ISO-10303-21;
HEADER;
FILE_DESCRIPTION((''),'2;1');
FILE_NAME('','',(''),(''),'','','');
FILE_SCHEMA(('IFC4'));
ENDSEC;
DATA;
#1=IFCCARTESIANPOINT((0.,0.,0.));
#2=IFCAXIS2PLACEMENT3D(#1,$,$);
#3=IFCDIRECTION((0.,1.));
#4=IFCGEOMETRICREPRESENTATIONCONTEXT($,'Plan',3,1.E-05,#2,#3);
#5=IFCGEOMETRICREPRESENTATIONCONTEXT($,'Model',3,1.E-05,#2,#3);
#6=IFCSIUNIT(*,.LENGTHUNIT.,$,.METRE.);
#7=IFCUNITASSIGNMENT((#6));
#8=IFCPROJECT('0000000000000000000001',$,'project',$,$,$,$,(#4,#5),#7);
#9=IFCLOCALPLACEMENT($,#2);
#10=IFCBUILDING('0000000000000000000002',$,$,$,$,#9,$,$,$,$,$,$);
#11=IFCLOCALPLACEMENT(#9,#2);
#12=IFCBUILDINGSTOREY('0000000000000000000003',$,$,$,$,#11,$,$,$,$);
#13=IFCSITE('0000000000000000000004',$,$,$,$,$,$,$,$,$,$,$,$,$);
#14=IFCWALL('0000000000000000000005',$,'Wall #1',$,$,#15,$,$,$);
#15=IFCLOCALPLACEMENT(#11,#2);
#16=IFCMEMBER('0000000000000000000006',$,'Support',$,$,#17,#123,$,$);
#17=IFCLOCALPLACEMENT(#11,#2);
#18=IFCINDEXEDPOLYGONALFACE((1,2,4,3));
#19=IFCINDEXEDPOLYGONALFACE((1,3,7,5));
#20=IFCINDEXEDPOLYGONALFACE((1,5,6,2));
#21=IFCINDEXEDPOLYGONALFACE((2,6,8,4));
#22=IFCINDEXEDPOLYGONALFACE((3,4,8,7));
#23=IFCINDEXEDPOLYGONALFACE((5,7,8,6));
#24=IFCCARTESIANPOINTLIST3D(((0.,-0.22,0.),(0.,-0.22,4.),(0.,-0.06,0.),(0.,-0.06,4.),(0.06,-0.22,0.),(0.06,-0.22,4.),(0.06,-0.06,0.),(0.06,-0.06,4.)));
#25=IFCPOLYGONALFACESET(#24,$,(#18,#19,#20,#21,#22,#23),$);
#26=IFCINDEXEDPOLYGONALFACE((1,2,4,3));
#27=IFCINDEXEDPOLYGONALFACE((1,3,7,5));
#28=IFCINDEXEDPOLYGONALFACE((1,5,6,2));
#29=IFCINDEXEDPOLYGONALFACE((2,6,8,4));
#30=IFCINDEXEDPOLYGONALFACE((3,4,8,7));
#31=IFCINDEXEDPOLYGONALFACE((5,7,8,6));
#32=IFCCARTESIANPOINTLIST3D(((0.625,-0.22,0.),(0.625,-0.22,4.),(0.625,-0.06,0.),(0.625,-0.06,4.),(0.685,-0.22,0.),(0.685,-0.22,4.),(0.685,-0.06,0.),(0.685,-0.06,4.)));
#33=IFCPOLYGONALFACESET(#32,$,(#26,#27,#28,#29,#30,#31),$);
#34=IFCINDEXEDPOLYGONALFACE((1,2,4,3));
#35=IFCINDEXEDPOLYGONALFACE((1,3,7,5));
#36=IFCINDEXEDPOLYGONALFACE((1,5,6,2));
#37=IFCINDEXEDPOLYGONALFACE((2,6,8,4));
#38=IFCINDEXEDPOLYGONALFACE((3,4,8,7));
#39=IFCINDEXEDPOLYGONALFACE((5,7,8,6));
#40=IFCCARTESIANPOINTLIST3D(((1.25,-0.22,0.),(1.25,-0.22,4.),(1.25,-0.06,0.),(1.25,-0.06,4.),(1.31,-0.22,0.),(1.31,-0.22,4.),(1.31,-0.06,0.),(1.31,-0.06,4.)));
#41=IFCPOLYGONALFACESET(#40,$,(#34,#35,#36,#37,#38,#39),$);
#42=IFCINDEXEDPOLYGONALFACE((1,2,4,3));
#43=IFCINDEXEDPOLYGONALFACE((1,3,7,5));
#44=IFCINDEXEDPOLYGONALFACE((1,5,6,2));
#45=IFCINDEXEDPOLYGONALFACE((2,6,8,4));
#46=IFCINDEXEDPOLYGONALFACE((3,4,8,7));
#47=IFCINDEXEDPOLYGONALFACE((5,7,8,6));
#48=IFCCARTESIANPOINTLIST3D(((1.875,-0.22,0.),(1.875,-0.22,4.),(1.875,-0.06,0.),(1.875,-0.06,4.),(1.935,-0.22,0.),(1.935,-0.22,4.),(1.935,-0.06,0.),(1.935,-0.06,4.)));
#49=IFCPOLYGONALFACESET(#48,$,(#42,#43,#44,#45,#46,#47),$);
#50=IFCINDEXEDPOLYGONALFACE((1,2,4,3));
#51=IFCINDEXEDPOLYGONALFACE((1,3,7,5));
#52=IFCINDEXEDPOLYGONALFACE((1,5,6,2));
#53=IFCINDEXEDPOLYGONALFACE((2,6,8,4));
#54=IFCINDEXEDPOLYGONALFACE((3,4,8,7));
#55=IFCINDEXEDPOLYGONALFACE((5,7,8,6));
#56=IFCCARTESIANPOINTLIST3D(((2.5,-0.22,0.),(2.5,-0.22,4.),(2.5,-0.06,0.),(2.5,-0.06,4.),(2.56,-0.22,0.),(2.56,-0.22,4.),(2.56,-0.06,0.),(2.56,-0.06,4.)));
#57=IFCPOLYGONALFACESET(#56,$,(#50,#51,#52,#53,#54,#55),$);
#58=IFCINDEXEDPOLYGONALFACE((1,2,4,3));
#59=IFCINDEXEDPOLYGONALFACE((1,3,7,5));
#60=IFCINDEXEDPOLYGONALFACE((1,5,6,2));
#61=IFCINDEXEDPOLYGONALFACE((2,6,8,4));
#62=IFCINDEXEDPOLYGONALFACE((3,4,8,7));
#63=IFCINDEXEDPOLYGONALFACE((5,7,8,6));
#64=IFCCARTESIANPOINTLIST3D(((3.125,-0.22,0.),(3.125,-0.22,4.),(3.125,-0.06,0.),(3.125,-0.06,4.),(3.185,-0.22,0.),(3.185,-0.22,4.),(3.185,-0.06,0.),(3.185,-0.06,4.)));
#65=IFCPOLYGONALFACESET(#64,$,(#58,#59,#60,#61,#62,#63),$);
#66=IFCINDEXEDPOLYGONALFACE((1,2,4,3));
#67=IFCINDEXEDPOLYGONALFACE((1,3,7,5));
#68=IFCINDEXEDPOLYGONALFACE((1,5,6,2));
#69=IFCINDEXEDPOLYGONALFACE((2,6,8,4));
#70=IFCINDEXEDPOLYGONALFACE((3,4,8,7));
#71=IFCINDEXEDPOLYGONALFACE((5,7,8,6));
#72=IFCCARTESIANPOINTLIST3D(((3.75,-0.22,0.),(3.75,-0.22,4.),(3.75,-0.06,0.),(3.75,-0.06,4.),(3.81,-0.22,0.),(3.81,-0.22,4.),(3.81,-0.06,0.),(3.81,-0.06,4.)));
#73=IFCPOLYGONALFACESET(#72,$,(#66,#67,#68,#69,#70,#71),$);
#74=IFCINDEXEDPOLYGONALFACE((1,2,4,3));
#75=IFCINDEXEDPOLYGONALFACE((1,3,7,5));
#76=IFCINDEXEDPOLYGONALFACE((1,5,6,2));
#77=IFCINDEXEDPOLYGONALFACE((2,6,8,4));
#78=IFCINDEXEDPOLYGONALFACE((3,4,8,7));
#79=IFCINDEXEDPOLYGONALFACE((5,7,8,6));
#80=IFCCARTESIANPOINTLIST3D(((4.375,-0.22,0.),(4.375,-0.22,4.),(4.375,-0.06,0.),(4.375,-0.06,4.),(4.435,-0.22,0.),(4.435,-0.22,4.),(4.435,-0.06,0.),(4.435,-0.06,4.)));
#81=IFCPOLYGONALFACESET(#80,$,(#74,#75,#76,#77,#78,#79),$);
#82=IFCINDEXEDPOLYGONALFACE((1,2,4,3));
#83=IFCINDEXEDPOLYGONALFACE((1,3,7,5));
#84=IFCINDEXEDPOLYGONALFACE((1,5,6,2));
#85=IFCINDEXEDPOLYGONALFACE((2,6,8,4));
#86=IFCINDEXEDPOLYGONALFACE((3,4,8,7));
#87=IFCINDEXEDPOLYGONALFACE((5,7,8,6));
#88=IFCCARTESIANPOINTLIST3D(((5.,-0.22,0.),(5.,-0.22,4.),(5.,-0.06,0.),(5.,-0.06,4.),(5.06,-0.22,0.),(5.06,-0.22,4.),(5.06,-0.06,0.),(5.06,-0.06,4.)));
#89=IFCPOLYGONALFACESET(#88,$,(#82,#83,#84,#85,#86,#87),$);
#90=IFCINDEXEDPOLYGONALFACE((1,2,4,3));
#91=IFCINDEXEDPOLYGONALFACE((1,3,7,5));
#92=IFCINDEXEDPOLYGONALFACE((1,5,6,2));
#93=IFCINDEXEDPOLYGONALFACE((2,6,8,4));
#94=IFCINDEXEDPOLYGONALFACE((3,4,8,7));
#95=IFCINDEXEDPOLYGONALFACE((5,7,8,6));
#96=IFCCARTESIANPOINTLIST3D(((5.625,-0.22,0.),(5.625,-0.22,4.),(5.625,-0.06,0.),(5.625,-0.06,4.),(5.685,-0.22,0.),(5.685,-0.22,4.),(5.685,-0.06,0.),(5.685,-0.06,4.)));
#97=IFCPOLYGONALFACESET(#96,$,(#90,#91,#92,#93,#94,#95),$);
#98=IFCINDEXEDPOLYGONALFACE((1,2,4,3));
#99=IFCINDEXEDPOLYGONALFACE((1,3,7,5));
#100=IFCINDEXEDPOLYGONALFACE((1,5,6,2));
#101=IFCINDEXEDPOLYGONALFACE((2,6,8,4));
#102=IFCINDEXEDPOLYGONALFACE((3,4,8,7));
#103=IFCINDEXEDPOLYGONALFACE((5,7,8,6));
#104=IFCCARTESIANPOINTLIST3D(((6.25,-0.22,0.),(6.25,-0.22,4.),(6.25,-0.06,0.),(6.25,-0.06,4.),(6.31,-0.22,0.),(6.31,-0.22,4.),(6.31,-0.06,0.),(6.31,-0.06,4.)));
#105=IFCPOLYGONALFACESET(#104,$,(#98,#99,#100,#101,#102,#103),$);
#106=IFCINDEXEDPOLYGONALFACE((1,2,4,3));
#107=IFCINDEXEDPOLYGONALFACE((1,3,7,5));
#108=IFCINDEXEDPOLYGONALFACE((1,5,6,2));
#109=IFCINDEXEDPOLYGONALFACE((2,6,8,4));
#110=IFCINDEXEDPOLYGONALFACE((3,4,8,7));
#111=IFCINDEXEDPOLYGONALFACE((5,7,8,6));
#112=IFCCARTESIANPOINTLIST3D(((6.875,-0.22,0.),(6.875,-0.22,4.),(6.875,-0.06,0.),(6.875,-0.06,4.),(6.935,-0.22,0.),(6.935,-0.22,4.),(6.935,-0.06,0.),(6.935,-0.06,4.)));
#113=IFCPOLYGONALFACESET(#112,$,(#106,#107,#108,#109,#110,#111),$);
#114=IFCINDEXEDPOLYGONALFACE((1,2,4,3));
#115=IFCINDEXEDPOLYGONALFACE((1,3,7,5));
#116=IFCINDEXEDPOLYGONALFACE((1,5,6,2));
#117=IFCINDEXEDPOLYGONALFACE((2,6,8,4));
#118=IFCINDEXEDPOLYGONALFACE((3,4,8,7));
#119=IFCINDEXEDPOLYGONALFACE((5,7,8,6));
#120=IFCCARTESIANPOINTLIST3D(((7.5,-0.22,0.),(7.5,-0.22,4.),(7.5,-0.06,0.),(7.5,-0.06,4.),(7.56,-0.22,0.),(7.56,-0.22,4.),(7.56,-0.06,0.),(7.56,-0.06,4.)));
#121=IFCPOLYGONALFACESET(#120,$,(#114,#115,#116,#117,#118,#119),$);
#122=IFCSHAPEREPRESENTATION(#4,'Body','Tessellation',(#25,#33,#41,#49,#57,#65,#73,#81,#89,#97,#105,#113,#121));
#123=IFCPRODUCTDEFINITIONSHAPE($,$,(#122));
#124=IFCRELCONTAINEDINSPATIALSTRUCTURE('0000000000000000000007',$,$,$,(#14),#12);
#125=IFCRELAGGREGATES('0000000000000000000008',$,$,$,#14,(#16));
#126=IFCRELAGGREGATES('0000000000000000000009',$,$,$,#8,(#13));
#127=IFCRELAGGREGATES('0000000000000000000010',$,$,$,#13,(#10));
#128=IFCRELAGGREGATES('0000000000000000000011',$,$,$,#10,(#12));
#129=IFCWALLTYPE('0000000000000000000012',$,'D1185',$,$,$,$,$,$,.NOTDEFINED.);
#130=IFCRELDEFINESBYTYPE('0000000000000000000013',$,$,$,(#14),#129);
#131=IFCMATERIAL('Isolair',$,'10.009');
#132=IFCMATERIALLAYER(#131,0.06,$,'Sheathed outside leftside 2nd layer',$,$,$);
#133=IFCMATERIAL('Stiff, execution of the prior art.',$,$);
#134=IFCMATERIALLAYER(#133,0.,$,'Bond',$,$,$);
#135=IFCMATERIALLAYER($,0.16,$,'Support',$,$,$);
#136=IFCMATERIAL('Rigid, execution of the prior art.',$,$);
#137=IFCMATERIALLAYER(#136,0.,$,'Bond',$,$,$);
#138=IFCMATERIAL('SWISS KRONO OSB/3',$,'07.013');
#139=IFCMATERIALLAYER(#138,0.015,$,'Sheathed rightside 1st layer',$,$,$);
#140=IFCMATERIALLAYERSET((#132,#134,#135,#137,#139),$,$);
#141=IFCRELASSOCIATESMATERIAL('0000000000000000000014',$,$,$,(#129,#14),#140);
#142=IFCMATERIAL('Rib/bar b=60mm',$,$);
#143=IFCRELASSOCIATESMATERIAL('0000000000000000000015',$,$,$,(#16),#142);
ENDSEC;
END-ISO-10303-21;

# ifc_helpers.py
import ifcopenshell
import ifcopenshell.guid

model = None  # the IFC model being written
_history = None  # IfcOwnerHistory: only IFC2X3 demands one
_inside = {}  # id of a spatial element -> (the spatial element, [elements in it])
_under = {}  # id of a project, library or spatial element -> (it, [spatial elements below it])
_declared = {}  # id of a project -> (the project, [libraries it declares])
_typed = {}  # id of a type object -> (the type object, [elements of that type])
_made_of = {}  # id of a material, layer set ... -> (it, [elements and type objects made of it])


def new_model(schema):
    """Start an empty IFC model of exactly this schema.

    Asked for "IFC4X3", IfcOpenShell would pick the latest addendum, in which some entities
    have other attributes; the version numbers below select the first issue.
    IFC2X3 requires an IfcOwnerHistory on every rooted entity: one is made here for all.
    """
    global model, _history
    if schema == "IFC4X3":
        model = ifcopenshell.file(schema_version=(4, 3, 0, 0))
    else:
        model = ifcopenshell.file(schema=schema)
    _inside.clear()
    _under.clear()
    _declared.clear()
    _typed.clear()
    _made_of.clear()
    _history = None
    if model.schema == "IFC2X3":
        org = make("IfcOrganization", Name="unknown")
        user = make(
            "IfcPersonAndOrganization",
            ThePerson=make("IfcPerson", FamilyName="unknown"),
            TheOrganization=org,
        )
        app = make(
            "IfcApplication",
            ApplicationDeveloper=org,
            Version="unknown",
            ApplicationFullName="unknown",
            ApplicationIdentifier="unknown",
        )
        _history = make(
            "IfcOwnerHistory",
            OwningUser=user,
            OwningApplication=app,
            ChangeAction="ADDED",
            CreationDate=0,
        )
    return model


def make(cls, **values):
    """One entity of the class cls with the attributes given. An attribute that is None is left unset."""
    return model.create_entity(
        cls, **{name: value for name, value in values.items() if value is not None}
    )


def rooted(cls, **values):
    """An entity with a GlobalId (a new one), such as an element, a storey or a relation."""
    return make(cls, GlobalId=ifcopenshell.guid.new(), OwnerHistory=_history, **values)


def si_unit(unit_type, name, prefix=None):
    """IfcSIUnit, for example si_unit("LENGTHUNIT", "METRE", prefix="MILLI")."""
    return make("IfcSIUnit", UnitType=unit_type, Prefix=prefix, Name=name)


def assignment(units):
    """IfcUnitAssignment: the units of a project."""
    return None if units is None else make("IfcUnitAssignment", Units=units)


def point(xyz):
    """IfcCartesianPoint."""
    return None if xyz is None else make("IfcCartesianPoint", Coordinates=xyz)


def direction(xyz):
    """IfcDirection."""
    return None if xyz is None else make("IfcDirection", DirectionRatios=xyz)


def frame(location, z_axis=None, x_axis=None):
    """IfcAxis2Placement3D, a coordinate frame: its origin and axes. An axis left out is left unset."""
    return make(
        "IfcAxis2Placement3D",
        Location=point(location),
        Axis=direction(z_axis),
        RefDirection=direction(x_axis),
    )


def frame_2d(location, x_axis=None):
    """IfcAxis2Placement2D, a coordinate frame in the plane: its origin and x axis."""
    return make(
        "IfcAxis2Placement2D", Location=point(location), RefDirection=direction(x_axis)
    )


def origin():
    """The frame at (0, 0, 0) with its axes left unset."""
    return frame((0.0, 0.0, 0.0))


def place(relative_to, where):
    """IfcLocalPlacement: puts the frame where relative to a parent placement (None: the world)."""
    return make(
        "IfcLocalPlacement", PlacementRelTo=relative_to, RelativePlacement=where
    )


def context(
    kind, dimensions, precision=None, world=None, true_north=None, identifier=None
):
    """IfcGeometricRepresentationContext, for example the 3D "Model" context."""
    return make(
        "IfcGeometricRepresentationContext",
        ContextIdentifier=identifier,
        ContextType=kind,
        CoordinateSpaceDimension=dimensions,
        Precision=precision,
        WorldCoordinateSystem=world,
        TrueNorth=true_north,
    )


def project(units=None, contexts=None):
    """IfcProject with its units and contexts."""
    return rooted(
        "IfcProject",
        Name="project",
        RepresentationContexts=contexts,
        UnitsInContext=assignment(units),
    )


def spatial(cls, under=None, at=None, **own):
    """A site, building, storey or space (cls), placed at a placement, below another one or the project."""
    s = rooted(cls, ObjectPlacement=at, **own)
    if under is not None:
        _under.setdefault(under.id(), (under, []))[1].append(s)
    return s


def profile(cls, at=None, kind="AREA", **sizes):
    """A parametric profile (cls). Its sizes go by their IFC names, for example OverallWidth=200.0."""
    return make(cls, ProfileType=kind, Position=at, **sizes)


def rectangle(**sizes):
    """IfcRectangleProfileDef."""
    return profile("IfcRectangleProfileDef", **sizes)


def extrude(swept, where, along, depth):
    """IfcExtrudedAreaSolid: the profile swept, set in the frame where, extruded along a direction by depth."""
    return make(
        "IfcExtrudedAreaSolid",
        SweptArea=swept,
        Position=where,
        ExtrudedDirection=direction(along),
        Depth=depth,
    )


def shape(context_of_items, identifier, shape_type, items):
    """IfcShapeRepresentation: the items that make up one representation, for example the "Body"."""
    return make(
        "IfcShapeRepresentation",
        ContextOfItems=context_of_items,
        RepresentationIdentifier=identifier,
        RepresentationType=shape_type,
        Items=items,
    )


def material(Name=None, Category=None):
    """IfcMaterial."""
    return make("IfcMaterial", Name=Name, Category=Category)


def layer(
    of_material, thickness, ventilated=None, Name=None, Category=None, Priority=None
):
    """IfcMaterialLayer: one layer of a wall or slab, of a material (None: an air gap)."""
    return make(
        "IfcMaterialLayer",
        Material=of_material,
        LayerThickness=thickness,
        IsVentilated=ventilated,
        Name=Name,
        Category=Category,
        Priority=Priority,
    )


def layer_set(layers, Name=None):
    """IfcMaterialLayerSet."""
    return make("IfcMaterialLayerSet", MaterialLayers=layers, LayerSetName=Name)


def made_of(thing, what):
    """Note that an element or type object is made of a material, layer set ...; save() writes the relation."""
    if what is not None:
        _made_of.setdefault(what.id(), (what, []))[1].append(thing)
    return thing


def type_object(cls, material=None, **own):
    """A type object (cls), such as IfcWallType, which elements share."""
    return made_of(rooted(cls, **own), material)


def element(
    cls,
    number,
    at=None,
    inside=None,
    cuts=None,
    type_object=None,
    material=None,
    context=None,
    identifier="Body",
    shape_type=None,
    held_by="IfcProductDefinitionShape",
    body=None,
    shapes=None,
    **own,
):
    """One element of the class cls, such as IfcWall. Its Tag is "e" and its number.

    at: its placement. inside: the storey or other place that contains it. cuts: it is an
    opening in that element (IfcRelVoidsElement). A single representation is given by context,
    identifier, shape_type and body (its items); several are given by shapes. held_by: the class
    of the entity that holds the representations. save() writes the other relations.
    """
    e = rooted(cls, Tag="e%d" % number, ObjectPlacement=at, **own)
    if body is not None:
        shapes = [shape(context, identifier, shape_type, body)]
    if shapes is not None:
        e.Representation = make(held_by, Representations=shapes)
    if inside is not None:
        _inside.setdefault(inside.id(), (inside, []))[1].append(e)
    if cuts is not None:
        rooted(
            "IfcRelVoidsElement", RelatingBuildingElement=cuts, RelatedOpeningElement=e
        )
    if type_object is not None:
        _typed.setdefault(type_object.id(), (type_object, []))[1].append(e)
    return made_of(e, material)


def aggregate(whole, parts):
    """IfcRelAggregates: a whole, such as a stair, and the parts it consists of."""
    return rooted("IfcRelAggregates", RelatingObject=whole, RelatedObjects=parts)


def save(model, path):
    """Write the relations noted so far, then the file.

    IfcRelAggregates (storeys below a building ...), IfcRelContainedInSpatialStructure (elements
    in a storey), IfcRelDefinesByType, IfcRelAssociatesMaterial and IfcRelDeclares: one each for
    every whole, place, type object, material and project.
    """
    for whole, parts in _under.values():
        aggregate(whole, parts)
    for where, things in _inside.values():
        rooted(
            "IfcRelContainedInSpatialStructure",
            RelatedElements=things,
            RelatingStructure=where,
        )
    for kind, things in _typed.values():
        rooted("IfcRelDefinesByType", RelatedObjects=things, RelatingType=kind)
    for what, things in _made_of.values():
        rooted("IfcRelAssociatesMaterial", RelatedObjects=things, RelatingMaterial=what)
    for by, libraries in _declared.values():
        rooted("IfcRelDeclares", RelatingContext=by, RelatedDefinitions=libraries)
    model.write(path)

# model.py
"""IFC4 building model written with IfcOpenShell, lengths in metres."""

from ifc_helpers import new_model, si_unit, direction, frame, frame_2d, origin, place, context, project, spatial, rectangle, extrude, material, layer, layer_set, type_object, element, aggregate, save


model = new_model("IFC4")

# Units and contexts
plan_context = context("Plan", 3, precision=1e-05, world=origin(), true_north=direction((0.0, 1.0)))
model_context = context("Model", 3, precision=1e-05, world=origin(), true_north=direction((0.0, 1.0)))
ifc_project = project(units=[si_unit("LENGTHUNIT", "METRE")], contexts=[plan_context, model_context])

# Site, building, storey
site = spatial("IfcSite", under=ifc_project)
building_placement = place(None, origin())
building = spatial("IfcBuilding", under=site, at=building_placement)
storey_placement = place(building_placement, origin())
storey = spatial("IfcBuildingStorey", under=building, at=storey_placement)

# Wall, member
ifc_material_1 = material(Name="Isolair", Category="10.009")
ifc_layer_1 = layer(ifc_material_1, 0.06, Name="Sheathed outside leftside 2nd layer")
ifc_material_2 = material(Name="Stiff, execution of the prior art.")
ifc_layer_2 = layer(ifc_material_2, 0.0, Name="Bond")
ifc_layer_3 = layer(None, 0.16, Name="Support")
ifc_material_3 = material(Name="Rigid, execution of the prior art.")
ifc_layer_4 = layer(ifc_material_3, 0.0, Name="Bond")
ifc_material_4 = material(Name="SWISS KRONO OSB/3", Category="07.013")
ifc_layer_5 = layer(ifc_material_4, 0.015, Name="Sheathed rightside 1st layer")
ifc_layer_set = layer_set([ifc_layer_1, ifc_layer_2, ifc_layer_3, ifc_layer_4, ifc_layer_5])
wall_type = type_object("IfcWallType", Name="D1185", PredefinedType="NOTDEFINED", material=ifc_layer_set)
wall_placement = place(None, frame((0.0, 0.0, 0.0), z_axis=(0.0, -1.0, 0.0), x_axis=(1.0, 0.0, 0.0)))
wall = element("IfcWall", 1, at=wall_placement, inside=storey, type_object=wall_type, material=ifc_layer_set, Name="Wall #1")
ifc_material_5 = material(Name="Rib/bar b=60mm")
member_1_placement = place(wall_placement, origin())
member_1 = element("IfcMember", 2, at=member_1_placement, material=ifc_material_5, Name="Support", context=plan_context, shape_type="SweptSolid", body=[
    extrude(rectangle(XDim=0.06, YDim=0.16, at=frame_2d((0.03, 0.08), x_axis=(1.0, 0.0))), frame((0.0, 4.0, 0.06), z_axis=(0.0, -1.0, 0.0), x_axis=(1.0, 0.0, 0.0)), (0.0, 0.0, 1.0), 4.0),
    extrude(rectangle(XDim=0.06, YDim=0.16, at=frame_2d((0.03, 0.08), x_axis=(1.0, 0.0))), frame((0.625, 4.0, 0.06), z_axis=(0.0, -1.0, 0.0), x_axis=(1.0, 0.0, 0.0)), (0.0, 0.0, 1.0), 4.0),
    extrude(rectangle(XDim=0.06, YDim=0.16, at=frame_2d((0.03, 0.08), x_axis=(1.0, 0.0))), frame((1.25, 4.0, 0.06), z_axis=(0.0, -1.0, 0.0), x_axis=(1.0, 0.0, 0.0)), (0.0, 0.0, 1.0), 4.0),
    extrude(rectangle(XDim=0.06, YDim=0.16, at=frame_2d((0.03, 0.08), x_axis=(1.0, 0.0))), frame((1.875, 4.0, 0.06), z_axis=(0.0, -1.0, 0.0), x_axis=(1.0, 0.0, 0.0)), (0.0, 0.0, 1.0), 4.0),
    extrude(rectangle(XDim=0.06, YDim=0.16, at=frame_2d((0.03, 0.08), x_axis=(1.0, 0.0))), frame((2.5, 4.0, 0.06), z_axis=(0.0, -1.0, 0.0), x_axis=(1.0, 0.0, 0.0)), (0.0, 0.0, 1.0), 4.0),
    extrude(rectangle(XDim=0.06, YDim=0.16, at=frame_2d((0.03, 0.08), x_axis=(1.0, 0.0))), frame((3.125, 4.0, 0.06), z_axis=(0.0, -1.0, 0.0), x_axis=(1.0, 0.0, 0.0)), (0.0, 0.0, 1.0), 4.0),
    extrude(rectangle(XDim=0.06, YDim=0.16, at=frame_2d((0.03, 0.08), x_axis=(1.0, 0.0))), frame((3.75, 4.0, 0.06), z_axis=(0.0, -1.0, 0.0), x_axis=(1.0, 0.0, 0.0)), (0.0, 0.0, 1.0), 4.0),
    extrude(rectangle(XDim=0.06, YDim=0.16, at=frame_2d((0.03, 0.08), x_axis=(1.0, 0.0))), frame((4.375, 4.0, 0.06), z_axis=(0.0, -1.0, 0.0), x_axis=(1.0, 0.0, 0.0)), (0.0, 0.0, 1.0), 4.0),
    extrude(rectangle(XDim=0.06, YDim=0.16, at=frame_2d((0.03, 0.08), x_axis=(1.0, 0.0))), frame((5.0, 4.0, 0.06), z_axis=(0.0, -1.0, 0.0), x_axis=(1.0, 0.0, 0.0)), (0.0, 0.0, 1.0), 4.0),
    extrude(rectangle(XDim=0.06, YDim=0.16, at=frame_2d((0.03, 0.08), x_axis=(1.0, 0.0))), frame((5.625, 4.0, 0.06), z_axis=(0.0, -1.0, 0.0), x_axis=(1.0, 0.0, 0.0)), (0.0, 0.0, 1.0), 4.0),
    extrude(rectangle(XDim=0.06, YDim=0.16, at=frame_2d((0.03, 0.08), x_axis=(1.0, 0.0))), frame((6.25, 4.0, 0.06), z_axis=(0.0, -1.0, 0.0), x_axis=(1.0, 0.0, 0.0)), (0.0, 0.0, 1.0), 4.0),
    extrude(rectangle(XDim=0.06, YDim=0.16, at=frame_2d((0.03, 0.08), x_axis=(1.0, 0.0))), frame((6.875, 4.0, 0.06), z_axis=(0.0, -1.0, 0.0), x_axis=(1.0, 0.0, 0.0)), (0.0, 0.0, 1.0), 4.0),
    extrude(rectangle(XDim=0.06, YDim=0.16, at=frame_2d((0.03, 0.08), x_axis=(1.0, 0.0))), frame((7.5, 4.0, 0.06), z_axis=(0.0, -1.0, 0.0), x_axis=(1.0, 0.0, 0.0)), (0.0, 0.0, 1.0), 4.0),
])
aggregate(wall, [member_1])

save(model, "model.ifc")
